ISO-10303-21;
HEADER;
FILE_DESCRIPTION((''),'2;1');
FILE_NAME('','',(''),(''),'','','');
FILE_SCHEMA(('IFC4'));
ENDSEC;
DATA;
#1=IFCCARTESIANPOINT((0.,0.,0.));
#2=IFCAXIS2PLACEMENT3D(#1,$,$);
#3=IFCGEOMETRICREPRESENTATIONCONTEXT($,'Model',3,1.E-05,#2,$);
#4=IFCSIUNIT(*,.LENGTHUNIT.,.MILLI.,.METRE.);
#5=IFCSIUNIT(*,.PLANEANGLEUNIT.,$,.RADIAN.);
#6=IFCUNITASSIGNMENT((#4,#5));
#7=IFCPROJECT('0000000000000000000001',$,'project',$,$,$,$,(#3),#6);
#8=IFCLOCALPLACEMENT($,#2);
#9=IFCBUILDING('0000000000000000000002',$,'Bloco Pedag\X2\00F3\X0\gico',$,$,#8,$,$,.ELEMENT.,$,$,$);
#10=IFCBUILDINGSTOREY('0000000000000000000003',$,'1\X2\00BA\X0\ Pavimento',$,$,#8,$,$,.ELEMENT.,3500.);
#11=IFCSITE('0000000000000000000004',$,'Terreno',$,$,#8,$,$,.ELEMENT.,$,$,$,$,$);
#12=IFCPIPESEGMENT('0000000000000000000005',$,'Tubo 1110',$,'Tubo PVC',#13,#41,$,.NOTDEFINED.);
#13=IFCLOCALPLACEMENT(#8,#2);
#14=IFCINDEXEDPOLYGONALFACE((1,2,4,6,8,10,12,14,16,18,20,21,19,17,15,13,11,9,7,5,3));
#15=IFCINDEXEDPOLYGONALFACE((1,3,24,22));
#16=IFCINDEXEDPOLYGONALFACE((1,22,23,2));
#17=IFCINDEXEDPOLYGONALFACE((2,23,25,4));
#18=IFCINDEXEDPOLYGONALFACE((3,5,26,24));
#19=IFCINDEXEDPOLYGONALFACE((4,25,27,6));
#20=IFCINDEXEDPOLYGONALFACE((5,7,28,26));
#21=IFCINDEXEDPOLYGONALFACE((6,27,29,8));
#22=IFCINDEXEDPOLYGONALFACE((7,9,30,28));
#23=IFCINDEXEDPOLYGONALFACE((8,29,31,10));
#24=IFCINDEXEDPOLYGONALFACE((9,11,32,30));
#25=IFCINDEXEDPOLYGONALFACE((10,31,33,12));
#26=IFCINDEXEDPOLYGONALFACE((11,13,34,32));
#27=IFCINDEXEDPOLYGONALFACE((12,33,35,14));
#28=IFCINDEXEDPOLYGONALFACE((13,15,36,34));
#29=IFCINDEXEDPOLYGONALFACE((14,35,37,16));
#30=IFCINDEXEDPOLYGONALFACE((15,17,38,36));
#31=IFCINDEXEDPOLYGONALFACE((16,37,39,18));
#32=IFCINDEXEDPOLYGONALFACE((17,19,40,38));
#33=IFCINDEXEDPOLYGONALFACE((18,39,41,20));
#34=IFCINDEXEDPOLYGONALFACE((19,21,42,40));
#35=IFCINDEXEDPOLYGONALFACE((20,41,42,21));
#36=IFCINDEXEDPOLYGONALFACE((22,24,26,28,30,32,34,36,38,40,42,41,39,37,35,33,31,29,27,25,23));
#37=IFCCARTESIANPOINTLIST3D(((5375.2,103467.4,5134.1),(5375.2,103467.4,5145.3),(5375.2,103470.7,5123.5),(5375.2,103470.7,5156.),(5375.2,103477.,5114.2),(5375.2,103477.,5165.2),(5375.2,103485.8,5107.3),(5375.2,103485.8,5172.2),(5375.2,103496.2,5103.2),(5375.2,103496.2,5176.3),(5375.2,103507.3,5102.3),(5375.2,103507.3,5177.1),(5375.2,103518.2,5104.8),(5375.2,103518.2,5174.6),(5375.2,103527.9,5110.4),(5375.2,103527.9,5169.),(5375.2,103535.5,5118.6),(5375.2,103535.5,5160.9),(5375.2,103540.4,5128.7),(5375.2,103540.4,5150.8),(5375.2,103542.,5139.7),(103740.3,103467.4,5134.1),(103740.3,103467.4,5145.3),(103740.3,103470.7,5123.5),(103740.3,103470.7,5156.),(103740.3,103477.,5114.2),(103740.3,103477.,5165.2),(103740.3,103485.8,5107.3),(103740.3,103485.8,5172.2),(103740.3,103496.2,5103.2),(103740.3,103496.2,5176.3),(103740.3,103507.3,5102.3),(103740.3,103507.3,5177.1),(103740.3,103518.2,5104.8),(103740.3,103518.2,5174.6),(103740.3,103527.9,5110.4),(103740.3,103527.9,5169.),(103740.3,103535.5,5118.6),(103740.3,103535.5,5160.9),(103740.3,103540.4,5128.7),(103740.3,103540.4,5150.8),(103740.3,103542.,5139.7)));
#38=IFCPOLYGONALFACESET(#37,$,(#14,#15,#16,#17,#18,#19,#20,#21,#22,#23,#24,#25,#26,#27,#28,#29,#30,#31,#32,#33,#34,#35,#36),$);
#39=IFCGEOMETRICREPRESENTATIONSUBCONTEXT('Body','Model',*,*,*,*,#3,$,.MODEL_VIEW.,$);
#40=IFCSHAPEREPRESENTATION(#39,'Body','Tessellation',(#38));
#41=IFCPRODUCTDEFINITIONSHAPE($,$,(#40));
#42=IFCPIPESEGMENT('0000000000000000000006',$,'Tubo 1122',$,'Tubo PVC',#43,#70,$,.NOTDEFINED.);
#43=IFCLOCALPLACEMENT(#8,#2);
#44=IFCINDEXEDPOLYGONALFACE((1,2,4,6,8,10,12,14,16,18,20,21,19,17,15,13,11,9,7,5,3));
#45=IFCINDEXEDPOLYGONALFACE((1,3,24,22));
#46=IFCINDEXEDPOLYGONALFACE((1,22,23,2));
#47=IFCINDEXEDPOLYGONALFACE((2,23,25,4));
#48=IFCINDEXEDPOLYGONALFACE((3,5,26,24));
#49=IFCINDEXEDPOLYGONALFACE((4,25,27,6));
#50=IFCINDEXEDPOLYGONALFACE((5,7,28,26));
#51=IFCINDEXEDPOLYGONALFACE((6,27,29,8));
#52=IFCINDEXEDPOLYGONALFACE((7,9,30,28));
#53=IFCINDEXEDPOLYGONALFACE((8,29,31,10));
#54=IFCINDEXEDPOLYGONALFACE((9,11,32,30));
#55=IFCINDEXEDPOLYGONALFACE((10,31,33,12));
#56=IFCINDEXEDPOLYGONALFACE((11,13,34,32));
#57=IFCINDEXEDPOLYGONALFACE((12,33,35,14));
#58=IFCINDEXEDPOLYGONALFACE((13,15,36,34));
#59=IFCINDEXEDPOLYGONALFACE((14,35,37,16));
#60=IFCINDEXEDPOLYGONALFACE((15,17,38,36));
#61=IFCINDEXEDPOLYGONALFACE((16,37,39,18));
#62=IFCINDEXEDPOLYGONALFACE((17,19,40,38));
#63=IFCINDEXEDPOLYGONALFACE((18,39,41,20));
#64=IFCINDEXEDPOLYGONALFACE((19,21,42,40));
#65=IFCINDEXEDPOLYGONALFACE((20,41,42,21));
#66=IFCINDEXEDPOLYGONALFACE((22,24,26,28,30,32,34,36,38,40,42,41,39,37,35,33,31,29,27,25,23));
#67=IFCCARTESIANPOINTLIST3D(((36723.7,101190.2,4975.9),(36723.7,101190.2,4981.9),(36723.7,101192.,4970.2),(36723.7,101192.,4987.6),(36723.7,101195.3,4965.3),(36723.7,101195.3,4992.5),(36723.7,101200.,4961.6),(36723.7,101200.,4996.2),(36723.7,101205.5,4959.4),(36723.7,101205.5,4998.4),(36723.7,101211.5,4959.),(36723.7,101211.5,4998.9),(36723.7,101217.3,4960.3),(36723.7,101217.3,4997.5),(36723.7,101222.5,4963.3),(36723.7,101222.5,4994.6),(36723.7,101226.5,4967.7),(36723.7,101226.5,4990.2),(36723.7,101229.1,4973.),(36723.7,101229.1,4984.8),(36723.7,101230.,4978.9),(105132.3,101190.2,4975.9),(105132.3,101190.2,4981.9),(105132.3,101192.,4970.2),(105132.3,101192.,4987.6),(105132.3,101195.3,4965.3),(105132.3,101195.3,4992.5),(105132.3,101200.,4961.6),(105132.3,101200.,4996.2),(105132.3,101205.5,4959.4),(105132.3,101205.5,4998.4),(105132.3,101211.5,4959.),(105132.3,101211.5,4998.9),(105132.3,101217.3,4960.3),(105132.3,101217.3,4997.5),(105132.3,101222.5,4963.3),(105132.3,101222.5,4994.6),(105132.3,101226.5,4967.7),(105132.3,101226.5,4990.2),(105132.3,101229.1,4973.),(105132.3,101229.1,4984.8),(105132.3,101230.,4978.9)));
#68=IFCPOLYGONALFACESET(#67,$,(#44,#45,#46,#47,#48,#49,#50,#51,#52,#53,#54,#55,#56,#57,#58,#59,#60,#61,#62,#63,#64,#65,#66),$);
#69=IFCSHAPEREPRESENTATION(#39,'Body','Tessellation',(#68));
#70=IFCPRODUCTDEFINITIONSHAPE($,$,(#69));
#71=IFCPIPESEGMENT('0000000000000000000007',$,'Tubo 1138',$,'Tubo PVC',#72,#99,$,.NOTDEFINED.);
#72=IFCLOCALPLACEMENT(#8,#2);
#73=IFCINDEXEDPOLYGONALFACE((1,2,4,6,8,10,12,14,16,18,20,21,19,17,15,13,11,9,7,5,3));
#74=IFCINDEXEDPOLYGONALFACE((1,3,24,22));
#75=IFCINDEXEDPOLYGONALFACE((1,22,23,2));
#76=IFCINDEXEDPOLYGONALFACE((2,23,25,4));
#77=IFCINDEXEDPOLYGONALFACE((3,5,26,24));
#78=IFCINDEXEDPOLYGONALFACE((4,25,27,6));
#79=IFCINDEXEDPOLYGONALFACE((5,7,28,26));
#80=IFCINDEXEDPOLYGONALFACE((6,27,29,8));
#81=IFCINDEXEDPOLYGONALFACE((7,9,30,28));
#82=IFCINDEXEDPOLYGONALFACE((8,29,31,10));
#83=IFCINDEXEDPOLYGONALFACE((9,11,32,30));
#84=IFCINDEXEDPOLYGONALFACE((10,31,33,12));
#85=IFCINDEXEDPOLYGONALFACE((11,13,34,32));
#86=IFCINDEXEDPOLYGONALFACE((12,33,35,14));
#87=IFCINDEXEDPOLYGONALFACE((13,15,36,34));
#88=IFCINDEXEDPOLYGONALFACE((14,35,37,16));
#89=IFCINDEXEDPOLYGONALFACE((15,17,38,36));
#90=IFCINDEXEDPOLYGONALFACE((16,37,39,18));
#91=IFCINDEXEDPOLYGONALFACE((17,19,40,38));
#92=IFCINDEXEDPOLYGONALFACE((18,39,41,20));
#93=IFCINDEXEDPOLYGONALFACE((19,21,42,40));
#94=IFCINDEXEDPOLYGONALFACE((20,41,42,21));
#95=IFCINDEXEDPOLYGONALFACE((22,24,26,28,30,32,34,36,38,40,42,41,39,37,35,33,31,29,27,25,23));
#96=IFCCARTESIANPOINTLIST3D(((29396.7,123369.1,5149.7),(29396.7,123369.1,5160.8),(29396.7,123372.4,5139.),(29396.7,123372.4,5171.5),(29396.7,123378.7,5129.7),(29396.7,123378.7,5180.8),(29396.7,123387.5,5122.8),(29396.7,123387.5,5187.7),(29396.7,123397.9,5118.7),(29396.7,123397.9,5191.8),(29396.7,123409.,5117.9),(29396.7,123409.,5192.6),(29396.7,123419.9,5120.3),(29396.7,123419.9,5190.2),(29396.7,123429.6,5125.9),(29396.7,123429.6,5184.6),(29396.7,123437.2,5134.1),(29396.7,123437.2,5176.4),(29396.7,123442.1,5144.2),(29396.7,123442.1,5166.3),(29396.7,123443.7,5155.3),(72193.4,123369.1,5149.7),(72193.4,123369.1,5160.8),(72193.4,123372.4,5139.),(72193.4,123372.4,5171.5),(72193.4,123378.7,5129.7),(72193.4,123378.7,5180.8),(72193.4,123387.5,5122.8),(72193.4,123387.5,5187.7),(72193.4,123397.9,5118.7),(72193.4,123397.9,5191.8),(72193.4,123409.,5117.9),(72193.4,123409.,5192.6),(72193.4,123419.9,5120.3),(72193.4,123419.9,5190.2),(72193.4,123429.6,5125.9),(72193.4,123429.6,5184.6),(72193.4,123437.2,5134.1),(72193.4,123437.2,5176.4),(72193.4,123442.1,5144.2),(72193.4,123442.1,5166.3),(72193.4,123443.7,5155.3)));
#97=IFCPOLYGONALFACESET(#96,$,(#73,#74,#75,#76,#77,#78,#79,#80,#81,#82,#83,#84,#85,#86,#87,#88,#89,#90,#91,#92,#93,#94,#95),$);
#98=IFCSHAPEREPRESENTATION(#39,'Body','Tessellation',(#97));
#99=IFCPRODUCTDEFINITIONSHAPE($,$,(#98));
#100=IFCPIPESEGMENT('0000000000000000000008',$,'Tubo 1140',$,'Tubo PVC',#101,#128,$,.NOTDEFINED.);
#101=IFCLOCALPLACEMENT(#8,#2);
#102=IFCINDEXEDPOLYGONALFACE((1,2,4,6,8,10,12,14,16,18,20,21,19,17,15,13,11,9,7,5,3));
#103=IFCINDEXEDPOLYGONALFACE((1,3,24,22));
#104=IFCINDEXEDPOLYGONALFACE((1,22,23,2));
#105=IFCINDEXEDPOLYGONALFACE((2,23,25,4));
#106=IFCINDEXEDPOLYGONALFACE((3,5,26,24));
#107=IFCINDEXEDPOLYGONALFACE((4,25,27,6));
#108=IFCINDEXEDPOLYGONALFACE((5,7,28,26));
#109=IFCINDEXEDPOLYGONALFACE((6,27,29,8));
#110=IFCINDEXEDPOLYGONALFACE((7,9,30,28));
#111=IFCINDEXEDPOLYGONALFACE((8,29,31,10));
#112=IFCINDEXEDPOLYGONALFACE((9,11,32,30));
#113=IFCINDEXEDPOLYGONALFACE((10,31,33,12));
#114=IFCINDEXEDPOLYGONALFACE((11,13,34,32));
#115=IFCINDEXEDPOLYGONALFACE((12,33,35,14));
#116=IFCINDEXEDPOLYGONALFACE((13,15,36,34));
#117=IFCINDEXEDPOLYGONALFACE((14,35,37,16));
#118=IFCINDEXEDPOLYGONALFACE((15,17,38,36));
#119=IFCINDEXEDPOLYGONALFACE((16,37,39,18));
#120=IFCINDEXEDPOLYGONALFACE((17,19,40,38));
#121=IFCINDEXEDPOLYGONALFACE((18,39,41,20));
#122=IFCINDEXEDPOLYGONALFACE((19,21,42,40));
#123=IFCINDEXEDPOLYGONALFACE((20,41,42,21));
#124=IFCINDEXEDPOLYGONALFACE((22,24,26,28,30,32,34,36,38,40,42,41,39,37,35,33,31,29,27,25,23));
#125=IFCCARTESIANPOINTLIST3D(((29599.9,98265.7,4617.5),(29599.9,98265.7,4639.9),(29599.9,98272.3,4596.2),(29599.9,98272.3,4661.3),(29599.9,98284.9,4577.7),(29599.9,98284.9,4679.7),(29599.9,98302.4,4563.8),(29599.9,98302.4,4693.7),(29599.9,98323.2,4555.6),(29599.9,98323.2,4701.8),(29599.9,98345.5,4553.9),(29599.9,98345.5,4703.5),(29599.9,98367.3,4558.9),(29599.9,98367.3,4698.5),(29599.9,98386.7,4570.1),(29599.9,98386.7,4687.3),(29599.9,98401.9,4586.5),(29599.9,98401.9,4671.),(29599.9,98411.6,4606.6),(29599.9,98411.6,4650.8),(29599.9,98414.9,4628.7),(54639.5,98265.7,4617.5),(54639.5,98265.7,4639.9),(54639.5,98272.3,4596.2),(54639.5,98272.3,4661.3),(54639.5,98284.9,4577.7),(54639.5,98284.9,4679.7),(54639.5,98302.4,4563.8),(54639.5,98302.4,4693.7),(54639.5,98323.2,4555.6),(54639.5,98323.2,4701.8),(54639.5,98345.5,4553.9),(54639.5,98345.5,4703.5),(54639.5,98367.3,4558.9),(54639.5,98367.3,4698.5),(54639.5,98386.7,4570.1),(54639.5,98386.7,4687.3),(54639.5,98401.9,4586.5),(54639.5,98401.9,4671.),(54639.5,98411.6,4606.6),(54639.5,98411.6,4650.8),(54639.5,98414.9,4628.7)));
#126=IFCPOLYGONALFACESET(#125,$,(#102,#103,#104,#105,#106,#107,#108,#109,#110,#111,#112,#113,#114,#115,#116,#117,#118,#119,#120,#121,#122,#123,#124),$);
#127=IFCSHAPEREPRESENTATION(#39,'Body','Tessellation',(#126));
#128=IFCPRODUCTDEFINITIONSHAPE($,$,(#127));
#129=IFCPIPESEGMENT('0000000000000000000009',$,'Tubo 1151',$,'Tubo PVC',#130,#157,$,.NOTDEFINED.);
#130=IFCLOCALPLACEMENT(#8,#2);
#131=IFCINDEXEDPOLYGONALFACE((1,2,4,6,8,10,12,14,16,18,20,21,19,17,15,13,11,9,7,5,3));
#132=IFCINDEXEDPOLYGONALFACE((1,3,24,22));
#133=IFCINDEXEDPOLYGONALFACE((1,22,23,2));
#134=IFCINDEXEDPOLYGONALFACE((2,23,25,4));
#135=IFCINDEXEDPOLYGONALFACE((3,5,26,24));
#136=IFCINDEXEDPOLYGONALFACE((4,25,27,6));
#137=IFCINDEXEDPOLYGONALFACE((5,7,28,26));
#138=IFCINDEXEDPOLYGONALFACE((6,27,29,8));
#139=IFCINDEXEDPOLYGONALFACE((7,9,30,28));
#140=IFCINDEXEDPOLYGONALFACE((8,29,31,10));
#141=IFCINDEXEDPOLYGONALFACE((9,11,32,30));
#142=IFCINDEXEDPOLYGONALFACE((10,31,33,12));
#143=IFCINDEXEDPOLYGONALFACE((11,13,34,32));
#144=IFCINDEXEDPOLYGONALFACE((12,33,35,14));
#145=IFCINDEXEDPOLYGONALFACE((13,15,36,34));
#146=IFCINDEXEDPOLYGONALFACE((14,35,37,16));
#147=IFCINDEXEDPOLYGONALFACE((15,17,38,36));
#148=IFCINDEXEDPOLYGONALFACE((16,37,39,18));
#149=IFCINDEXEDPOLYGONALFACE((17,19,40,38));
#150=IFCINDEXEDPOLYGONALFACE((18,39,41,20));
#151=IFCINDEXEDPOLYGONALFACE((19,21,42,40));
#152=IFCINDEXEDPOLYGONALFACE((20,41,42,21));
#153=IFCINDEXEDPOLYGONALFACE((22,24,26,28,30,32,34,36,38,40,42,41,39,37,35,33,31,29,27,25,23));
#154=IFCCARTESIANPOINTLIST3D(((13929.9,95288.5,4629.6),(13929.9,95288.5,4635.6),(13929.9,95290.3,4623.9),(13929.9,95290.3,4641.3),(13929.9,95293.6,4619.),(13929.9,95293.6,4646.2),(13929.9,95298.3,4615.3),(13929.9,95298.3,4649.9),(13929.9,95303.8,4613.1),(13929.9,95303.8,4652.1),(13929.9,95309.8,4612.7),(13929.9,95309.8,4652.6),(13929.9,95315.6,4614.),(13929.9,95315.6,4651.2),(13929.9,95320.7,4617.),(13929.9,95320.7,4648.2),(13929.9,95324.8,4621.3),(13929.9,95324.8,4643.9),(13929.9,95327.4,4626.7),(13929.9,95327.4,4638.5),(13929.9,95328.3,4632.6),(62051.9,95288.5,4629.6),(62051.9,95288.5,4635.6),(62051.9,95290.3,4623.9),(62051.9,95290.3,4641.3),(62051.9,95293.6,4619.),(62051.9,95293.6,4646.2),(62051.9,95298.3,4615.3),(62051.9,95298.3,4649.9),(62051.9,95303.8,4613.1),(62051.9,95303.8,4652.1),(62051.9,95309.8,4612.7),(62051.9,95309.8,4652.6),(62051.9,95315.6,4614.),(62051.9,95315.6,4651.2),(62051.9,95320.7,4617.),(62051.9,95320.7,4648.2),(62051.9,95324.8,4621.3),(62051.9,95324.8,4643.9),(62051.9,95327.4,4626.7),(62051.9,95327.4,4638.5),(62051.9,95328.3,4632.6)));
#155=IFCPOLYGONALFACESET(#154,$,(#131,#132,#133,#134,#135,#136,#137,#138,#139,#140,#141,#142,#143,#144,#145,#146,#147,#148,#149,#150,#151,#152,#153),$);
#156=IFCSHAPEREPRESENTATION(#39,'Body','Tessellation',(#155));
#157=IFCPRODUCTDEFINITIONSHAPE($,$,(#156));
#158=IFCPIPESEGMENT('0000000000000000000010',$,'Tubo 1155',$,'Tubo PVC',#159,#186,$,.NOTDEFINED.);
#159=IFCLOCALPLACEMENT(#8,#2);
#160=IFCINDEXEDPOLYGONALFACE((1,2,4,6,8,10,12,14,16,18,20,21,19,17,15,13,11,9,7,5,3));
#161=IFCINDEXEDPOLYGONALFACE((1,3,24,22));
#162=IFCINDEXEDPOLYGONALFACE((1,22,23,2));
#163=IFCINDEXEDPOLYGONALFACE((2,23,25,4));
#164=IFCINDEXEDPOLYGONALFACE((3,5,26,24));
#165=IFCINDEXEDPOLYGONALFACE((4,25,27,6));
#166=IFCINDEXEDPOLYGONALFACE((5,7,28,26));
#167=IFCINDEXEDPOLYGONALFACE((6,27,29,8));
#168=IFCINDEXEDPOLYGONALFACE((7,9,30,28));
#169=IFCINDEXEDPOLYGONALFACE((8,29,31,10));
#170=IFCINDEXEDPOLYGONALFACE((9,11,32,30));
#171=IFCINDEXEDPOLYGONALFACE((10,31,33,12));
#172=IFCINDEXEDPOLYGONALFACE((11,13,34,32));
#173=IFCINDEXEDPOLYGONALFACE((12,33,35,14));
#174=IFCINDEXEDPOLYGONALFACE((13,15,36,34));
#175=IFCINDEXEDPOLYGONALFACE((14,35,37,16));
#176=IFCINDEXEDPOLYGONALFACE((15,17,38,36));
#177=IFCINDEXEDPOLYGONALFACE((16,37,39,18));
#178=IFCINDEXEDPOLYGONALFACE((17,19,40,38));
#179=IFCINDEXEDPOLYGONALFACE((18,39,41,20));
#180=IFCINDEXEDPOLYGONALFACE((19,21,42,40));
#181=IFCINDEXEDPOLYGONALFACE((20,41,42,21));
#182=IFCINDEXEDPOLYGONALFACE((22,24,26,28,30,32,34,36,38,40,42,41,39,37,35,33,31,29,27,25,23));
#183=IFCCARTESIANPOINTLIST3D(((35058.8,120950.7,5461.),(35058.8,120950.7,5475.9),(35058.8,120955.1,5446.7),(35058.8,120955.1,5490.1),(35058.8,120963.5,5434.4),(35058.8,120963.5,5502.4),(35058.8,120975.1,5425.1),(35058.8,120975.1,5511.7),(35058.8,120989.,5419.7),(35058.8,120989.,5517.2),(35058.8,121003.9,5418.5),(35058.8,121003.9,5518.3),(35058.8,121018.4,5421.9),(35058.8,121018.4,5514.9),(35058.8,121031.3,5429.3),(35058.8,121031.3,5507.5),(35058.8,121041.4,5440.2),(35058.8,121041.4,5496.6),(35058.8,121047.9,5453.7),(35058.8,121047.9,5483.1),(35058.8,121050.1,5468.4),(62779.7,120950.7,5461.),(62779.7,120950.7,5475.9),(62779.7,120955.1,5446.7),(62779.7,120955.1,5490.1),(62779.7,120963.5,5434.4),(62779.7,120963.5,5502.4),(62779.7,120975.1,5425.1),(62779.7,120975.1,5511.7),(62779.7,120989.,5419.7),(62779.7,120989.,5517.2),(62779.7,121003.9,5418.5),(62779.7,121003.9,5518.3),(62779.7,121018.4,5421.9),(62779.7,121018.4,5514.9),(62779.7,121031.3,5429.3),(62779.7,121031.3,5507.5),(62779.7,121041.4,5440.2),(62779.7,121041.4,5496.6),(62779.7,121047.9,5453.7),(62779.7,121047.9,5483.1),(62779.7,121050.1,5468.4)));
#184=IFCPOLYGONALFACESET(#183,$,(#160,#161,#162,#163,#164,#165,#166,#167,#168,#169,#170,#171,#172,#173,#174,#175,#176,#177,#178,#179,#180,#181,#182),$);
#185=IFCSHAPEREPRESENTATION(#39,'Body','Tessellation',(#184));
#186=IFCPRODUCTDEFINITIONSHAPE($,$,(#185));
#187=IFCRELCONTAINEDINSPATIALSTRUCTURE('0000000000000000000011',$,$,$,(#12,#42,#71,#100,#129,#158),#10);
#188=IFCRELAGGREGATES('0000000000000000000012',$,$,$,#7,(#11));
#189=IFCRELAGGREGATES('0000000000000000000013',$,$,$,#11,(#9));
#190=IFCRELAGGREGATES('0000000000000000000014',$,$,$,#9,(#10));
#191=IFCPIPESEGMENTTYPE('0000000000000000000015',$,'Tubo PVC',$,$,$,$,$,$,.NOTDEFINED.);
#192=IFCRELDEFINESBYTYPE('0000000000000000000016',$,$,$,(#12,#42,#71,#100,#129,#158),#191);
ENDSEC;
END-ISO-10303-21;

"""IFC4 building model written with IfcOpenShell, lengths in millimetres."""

from ifc_helpers import new_model, si_unit, frame, origin, origin_2d, place, context, subcontext, project, spatial, circle, extrude, type_object, element, save


model = new_model("IFC4")

# Units and contexts
model_context = context("Model", 3, precision=1e-05, world=origin())
body_context = subcontext(model_context, "Body", "Model", "MODEL_VIEW")
ifc_project = project(units=[si_unit("LENGTHUNIT", "METRE", prefix="MILLI"), si_unit("PLANEANGLEUNIT", "RADIAN")], contexts=[model_context])

# Site, building, storey
placement = place(None, origin())
site = spatial("IfcSite", under=ifc_project, at=placement, Name="Terreno", CompositionType="ELEMENT")
building = spatial("IfcBuilding", under=site, at=placement, Name="Bloco Pedagógico", CompositionType="ELEMENT")
storey = spatial("IfcBuildingStorey", under=building, at=placement, Name="1º Pavimento", CompositionType="ELEMENT", Elevation=3500.0)

# Pipe segments
pipe_segment_type = type_object("IfcPipeSegmentType", Name="Tubo PVC", PredefinedType="NOTDEFINED")
pipe_segment_1_placement = place(None, frame((5375.2, 103504.5, 5139.7), z_axis=(1.0, 0.0, 0.0), x_axis=(0.0, 1.0, 0.0)))
element("IfcPipeSegment", 1, at=pipe_segment_1_placement, inside=storey, type_object=pipe_segment_type, Name="Tubo 1110", ObjectType="Tubo PVC", PredefinedType="NOTDEFINED", context=body_context, shape_type="SweptSolid", body=[
    extrude(circle(Radius=37.5, at=origin_2d()), None, (0.0, 0.0, 1.0), 98365.1),
])
pipe_segment_2_placement = place(None, frame((36723.7, 101210.0, 4978.9), z_axis=(1.0, 0.0, 0.0), x_axis=(0.0, 1.0, 0.0)))
element("IfcPipeSegment", 2, at=pipe_segment_2_placement, inside=storey, type_object=pipe_segment_type, Name="Tubo 1122", ObjectType="Tubo PVC", PredefinedType="NOTDEFINED", context=body_context, shape_type="SweptSolid", body=[
    extrude(circle(Radius=20.0, at=origin_2d()), None, (0.0, 0.0, 1.0), 68408.6),
])
pipe_segment_3_placement = place(None, frame((29396.7, 123406.2, 5155.3), z_axis=(1.0, 0.0, 0.0), x_axis=(0.0, 1.0, 0.0)))
element("IfcPipeSegment", 3, at=pipe_segment_3_placement, inside=storey, type_object=pipe_segment_type, Name="Tubo 1138", ObjectType="Tubo PVC", PredefinedType="NOTDEFINED", context=body_context, shape_type="SweptSolid", body=[
    extrude(circle(Radius=37.5, at=origin_2d()), None, (0.0, 0.0, 1.0), 42796.7),
])
pipe_segment_4_placement = place(None, frame((29599.9, 98339.9, 4628.7), z_axis=(1.0, 0.0, 0.0), x_axis=(0.0, 1.0, 0.0)))
element("IfcPipeSegment", 4, at=pipe_segment_4_placement, inside=storey, type_object=pipe_segment_type, Name="Tubo 1140", ObjectType="Tubo PVC", PredefinedType="NOTDEFINED", context=body_context, shape_type="SweptSolid", body=[
    extrude(circle(Radius=75.0, at=origin_2d()), None, (0.0, 0.0, 1.0), 25039.7),
])
pipe_segment_5_placement = place(None, frame((13929.9, 95308.3, 4632.6), z_axis=(1.0, 0.0, 0.0), x_axis=(0.0, 1.0, 0.0)))
element("IfcPipeSegment", 5, at=pipe_segment_5_placement, inside=storey, type_object=pipe_segment_type, Name="Tubo 1151", ObjectType="Tubo PVC", PredefinedType="NOTDEFINED", context=body_context, shape_type="SweptSolid", body=[
    extrude(circle(Radius=20.0, at=origin_2d()), None, (0.0, 0.0, 1.0), 48122.0),
])
pipe_segment_6_placement = place(None, frame((35058.8, 121000.1, 5468.4), z_axis=(1.0, 0.0, 0.0), x_axis=(0.0, 1.0, 0.0)))
element("IfcPipeSegment", 6, at=pipe_segment_6_placement, inside=storey, type_object=pipe_segment_type, Name="Tubo 1155", ObjectType="Tubo PVC", PredefinedType="NOTDEFINED", context=body_context, shape_type="SweptSolid", body=[
    extrude(circle(Radius=50.0, at=origin_2d()), None, (0.0, 0.0, 1.0), 27720.9),
])

save(model, "model.ifc")
